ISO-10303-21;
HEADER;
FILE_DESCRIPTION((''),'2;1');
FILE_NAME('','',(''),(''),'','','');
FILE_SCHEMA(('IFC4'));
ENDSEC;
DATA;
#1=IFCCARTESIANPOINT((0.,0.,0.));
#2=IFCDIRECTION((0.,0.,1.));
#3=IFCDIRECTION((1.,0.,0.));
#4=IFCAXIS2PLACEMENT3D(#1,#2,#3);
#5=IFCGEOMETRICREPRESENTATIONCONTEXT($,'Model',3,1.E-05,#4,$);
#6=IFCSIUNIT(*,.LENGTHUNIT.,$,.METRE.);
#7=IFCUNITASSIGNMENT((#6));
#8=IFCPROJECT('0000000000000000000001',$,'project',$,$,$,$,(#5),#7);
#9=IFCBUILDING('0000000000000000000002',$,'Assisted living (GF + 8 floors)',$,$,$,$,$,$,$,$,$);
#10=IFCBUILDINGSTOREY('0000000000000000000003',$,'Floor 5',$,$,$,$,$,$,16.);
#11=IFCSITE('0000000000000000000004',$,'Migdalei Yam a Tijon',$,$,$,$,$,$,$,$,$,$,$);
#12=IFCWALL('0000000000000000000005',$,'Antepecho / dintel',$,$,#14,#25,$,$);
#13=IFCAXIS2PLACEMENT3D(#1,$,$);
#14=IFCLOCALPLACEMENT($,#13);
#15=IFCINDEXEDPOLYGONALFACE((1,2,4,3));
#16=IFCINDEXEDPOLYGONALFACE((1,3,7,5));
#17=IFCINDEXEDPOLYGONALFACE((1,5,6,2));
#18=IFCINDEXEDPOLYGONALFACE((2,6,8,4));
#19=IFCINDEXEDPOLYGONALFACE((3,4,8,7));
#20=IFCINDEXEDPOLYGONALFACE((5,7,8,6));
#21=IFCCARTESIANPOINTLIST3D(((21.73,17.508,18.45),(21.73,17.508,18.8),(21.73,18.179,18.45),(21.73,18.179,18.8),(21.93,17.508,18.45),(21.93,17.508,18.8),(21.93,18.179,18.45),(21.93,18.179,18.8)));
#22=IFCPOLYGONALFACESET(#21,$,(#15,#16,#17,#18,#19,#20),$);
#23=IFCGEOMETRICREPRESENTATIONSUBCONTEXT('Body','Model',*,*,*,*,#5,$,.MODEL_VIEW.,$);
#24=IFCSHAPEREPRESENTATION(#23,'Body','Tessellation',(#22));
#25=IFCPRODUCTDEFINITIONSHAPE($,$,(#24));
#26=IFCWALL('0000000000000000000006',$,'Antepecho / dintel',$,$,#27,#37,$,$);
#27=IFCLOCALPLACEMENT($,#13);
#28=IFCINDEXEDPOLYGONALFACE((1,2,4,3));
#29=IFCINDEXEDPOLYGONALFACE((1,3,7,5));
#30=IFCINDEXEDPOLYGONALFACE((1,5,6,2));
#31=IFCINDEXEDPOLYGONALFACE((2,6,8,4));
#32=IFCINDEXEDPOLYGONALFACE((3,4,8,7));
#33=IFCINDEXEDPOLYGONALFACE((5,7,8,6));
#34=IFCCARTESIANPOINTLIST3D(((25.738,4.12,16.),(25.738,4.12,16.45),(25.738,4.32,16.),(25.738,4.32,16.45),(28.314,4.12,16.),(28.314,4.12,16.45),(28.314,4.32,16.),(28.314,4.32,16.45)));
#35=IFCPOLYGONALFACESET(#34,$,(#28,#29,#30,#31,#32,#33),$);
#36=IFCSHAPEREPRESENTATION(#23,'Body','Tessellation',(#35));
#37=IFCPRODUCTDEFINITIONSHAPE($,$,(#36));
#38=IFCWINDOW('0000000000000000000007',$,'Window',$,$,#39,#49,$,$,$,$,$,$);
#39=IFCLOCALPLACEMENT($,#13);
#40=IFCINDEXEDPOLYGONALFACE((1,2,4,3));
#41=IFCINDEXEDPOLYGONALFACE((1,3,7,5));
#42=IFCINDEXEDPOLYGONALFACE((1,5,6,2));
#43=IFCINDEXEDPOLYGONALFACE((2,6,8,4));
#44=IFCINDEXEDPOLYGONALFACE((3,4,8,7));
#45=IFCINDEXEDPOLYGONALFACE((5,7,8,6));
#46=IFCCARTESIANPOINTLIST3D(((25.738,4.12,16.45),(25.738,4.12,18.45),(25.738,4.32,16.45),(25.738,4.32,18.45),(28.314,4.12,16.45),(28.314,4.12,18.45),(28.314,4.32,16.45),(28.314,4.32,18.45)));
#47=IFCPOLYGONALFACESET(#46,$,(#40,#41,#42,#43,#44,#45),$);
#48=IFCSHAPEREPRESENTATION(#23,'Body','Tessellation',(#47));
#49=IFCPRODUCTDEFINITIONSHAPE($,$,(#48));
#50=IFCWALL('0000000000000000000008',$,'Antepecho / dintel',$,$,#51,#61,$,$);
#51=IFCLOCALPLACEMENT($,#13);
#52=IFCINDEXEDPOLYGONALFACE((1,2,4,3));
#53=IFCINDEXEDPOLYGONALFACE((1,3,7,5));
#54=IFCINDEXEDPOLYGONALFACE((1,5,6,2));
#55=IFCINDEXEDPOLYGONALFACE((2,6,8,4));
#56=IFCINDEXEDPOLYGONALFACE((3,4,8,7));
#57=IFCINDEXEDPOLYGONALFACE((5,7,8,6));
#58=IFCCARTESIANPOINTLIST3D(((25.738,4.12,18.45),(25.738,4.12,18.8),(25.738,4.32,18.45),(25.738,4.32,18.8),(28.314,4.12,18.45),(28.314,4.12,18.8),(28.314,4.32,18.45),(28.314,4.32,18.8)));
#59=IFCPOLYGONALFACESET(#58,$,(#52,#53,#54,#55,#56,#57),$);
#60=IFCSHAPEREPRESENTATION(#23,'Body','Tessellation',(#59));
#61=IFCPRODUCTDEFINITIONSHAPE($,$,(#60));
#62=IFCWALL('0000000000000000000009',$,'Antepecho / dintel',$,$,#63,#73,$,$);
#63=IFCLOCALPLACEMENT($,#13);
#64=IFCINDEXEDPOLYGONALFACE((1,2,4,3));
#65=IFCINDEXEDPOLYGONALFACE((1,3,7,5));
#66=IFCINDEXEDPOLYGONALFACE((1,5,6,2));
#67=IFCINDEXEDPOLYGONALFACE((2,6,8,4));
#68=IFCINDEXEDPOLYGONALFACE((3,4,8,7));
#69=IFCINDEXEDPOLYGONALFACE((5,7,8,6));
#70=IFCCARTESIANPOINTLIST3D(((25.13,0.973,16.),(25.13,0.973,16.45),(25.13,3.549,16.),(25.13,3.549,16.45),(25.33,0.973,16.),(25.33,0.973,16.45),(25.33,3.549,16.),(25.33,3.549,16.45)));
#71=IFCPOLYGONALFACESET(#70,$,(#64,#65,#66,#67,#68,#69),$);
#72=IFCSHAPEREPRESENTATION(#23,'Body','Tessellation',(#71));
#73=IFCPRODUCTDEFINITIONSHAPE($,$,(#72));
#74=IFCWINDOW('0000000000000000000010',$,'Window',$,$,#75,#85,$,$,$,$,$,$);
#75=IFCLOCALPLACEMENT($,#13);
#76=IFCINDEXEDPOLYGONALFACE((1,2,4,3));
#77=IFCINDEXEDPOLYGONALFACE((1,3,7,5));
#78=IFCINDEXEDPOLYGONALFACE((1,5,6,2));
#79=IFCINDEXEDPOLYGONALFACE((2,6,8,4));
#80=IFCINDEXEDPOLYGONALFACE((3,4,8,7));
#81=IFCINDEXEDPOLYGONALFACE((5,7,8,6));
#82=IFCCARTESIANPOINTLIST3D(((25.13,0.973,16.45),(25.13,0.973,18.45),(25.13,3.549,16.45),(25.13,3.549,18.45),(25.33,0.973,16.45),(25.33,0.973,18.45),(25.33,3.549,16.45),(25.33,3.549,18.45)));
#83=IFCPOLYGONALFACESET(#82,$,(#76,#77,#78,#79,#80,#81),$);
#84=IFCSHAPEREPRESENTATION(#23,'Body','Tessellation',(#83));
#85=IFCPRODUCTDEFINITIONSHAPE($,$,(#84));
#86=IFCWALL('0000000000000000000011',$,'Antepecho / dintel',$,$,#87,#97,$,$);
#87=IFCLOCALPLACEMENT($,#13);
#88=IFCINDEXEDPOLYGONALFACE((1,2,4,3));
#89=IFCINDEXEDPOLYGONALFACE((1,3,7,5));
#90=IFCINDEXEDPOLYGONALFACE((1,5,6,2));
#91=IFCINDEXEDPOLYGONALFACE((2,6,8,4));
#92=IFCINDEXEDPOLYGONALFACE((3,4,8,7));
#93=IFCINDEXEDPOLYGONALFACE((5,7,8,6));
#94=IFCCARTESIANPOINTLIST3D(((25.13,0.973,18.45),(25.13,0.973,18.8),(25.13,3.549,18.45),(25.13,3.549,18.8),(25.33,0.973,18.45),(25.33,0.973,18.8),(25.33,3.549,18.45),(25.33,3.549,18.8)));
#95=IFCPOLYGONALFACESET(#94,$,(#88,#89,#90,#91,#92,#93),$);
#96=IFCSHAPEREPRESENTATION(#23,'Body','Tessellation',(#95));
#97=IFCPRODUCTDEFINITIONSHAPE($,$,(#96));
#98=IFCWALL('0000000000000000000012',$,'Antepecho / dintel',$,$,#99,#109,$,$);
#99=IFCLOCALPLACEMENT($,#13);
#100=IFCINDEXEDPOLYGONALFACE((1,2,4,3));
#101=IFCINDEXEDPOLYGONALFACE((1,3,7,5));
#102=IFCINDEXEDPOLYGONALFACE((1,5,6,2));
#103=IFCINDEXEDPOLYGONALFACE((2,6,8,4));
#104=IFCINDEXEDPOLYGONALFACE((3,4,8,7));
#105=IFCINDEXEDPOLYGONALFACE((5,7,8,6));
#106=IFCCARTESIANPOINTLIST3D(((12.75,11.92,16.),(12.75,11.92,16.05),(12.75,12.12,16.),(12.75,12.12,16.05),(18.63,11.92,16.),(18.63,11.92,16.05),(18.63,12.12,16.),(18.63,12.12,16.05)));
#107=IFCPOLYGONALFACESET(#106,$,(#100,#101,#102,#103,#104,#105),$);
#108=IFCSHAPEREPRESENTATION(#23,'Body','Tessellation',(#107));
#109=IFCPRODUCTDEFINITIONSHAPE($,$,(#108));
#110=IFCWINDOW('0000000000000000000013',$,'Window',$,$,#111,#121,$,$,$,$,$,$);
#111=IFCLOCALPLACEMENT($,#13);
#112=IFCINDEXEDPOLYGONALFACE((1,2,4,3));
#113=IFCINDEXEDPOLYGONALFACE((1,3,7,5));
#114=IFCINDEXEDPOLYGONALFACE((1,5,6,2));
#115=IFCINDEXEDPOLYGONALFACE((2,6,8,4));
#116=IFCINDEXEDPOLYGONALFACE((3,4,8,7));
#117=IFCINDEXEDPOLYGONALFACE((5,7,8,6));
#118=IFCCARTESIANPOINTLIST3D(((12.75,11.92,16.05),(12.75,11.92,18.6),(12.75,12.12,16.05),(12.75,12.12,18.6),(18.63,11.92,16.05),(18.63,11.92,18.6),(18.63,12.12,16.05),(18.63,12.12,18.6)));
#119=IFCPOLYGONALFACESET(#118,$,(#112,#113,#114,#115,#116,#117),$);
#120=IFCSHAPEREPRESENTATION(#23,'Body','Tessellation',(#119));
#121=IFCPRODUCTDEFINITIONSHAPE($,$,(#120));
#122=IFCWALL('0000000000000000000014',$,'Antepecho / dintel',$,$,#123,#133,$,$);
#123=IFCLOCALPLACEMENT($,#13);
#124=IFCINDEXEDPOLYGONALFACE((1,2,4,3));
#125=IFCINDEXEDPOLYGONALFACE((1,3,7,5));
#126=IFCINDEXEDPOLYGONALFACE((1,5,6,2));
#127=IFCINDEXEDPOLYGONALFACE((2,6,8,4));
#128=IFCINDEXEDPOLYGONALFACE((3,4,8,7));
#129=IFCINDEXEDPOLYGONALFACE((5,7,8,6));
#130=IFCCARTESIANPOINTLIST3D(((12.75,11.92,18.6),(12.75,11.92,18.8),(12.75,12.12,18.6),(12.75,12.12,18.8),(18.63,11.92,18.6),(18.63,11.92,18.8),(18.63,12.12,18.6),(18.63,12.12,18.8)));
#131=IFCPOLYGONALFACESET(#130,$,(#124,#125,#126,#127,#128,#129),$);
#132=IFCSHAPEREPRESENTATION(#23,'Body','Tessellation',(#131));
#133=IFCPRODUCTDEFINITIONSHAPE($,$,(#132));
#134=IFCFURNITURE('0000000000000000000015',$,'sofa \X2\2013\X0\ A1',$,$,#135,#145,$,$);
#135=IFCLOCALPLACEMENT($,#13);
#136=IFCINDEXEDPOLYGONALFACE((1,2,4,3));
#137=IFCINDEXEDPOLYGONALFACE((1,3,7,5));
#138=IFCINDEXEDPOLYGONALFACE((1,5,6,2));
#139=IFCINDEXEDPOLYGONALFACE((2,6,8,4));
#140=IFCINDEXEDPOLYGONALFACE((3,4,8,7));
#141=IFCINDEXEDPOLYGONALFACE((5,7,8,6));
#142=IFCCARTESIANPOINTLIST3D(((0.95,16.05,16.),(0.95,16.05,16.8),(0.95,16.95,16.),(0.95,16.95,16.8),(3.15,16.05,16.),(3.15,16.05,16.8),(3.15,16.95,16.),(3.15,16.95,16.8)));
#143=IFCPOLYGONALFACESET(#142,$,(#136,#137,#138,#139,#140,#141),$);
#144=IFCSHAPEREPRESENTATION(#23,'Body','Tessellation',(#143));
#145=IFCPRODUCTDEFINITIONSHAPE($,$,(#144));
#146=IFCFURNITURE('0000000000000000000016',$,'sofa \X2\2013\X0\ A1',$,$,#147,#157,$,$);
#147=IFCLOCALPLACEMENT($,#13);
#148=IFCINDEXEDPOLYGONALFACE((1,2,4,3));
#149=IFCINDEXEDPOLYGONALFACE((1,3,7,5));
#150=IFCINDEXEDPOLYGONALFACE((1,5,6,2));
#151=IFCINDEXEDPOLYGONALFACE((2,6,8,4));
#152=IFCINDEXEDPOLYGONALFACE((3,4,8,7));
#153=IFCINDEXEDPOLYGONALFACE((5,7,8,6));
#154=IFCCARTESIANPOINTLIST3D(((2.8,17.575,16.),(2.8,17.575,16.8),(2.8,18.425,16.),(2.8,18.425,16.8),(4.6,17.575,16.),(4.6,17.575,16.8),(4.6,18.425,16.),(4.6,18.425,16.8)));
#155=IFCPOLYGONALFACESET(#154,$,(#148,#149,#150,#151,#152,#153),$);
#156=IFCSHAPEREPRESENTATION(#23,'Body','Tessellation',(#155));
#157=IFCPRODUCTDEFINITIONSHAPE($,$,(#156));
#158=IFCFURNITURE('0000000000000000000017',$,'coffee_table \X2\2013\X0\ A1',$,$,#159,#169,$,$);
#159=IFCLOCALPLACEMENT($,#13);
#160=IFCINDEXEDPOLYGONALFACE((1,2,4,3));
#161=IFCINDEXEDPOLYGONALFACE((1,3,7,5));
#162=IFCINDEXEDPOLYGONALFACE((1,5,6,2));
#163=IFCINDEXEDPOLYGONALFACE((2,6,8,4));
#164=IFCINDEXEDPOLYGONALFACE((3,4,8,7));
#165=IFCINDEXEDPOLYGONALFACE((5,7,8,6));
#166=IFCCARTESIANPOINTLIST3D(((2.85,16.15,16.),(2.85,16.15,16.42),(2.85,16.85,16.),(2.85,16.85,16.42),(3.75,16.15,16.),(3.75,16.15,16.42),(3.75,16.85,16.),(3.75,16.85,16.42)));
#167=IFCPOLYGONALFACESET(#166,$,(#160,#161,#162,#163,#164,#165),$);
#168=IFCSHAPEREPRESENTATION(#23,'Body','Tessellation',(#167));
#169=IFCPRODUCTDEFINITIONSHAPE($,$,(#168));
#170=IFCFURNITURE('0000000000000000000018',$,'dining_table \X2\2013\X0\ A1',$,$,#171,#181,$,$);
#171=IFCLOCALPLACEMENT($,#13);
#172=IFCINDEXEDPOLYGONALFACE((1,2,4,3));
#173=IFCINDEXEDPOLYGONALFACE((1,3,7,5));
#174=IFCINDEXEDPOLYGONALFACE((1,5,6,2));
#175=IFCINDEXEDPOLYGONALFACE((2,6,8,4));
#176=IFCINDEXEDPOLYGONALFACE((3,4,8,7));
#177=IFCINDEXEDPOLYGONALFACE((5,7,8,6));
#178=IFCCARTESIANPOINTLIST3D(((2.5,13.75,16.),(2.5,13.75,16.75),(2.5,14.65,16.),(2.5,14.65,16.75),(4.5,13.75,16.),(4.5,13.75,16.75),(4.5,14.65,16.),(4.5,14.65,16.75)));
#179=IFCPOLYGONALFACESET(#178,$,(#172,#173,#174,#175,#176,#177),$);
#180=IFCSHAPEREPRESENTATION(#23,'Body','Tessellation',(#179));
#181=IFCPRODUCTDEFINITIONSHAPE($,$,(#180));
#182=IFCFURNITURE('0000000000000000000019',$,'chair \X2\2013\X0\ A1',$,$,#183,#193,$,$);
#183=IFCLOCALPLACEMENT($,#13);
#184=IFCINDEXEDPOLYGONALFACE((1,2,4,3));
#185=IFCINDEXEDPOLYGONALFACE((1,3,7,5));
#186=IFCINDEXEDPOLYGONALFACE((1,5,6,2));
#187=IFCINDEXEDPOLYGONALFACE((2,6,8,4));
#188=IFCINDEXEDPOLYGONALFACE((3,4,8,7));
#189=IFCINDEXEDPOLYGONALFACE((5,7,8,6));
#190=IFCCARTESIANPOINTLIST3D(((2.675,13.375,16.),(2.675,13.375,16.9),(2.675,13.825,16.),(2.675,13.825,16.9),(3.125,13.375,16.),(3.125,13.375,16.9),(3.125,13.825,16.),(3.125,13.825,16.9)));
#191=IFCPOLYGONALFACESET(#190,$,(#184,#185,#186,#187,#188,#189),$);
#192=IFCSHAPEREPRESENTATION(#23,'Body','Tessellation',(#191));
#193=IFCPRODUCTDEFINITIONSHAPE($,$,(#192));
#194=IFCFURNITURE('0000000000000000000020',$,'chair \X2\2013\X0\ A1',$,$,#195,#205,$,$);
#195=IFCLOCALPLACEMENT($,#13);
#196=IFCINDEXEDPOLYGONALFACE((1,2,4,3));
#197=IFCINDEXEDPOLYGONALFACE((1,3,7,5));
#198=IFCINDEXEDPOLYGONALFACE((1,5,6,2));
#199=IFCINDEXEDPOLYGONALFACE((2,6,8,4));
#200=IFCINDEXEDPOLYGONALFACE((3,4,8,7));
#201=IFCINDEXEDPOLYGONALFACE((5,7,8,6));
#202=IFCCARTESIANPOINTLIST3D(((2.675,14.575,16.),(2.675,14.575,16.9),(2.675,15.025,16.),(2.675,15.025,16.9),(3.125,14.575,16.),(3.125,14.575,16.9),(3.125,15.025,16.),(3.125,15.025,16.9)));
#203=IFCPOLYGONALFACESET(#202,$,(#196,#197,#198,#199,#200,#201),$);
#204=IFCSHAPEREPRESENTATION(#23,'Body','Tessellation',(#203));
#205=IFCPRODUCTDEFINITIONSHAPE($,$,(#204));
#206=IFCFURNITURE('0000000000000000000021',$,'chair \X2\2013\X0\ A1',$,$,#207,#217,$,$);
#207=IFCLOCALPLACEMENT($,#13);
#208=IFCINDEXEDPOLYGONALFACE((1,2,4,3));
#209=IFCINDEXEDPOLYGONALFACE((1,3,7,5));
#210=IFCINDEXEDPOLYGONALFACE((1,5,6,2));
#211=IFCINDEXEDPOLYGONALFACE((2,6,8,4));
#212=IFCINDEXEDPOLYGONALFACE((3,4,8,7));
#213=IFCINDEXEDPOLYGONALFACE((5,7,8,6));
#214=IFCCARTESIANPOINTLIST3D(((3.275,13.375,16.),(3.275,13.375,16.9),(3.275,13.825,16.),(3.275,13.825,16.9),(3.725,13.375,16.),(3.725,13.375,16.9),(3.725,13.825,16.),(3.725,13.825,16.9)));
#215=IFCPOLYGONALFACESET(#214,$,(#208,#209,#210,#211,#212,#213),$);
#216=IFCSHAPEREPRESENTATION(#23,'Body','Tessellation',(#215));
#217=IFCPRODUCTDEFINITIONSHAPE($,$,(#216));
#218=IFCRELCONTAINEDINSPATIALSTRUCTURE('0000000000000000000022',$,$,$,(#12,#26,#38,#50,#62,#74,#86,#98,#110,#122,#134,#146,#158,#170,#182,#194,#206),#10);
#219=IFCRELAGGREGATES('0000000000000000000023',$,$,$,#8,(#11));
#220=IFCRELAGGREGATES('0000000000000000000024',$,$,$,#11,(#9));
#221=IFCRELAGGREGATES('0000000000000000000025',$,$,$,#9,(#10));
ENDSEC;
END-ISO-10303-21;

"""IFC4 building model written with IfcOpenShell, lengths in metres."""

from ifc_helpers import new_model, si_unit, frame, origin_with_axes, context, subcontext, project, spatial, line, indexed_curve, outline, extrude, element, save


model = new_model("IFC4")

# Units and contexts
model_context = context("Model", 3, precision=1e-05, world=origin_with_axes())
body_context = subcontext(model_context, "Body", "Model", "MODEL_VIEW")
ifc_project = project(units=[si_unit("LENGTHUNIT", "METRE")], contexts=[model_context])

# Site, building, storey
site = spatial("IfcSite", under=ifc_project, Name="Migdalei Yam a Tijon")
building = spatial("IfcBuilding", under=site, Name="Assisted living (GF + 8 floors)")
storey = spatial("IfcBuildingStorey", under=building, Name="Floor 5", Elevation=16.0)

# Walls
element("IfcWall", 1, inside=storey, Name="Antepecho / dintel", context=body_context, shape_type="SweptSolid", body=[
    extrude(outline(indexed_curve([(0.0, 0.0), (0.2, 0.0), (0.2, 0.671), (0.0, 0.671)], segments=[line(1, 2, 3, 4, 1)])), frame((21.73, 17.508, 18.45), z_axis=(0.0, 0.0, 1.0), x_axis=(1.0, 0.0, 0.0)), (0.0, 0.0, 1.0), 0.35),
])
element("IfcWall", 2, inside=storey, Name="Antepecho / dintel", context=body_context, shape_type="SweptSolid", body=[
    extrude(outline(indexed_curve([(0.0, 0.0), (2.576, 0.0), (2.576, 0.2), (0.0, 0.2)], segments=[line(1, 2, 3, 4, 1)])), frame((25.738, 4.12, 16.0), z_axis=(0.0, 0.0, 1.0), x_axis=(1.0, 0.0, 0.0)), (0.0, 0.0, 1.0), 0.45),
])

# Window
element("IfcWindow", 3, inside=storey, Name="Window", context=body_context, shape_type="SweptSolid", body=[
    extrude(outline(indexed_curve([(0.0, 0.0), (2.576, 0.0), (2.576, 0.2), (0.0, 0.2)], segments=[line(1, 2, 3, 4, 1)])), frame((25.738, 4.12, 16.45), z_axis=(0.0, 0.0, 1.0), x_axis=(1.0, 0.0, 0.0)), (0.0, 0.0, 1.0), 2.0),
])

# Walls
element("IfcWall", 4, inside=storey, Name="Antepecho / dintel", context=body_context, shape_type="SweptSolid", body=[
    extrude(outline(indexed_curve([(0.0, 0.0), (2.576, 0.0), (2.576, 0.2), (0.0, 0.2)], segments=[line(1, 2, 3, 4, 1)])), frame((25.738, 4.12, 18.45), z_axis=(0.0, 0.0, 1.0), x_axis=(1.0, 0.0, 0.0)), (0.0, 0.0, 1.0), 0.35),
])
element("IfcWall", 5, inside=storey, Name="Antepecho / dintel", context=body_context, shape_type="SweptSolid", body=[
    extrude(outline(indexed_curve([(0.0, 0.0), (0.2, 0.0), (0.2, 2.576), (0.0, 2.576)], segments=[line(1, 2, 3, 4, 1)])), frame((25.13, 0.973, 16.0), z_axis=(0.0, 0.0, 1.0), x_axis=(1.0, 0.0, 0.0)), (0.0, 0.0, 1.0), 0.45),
])

# Window
element("IfcWindow", 6, inside=storey, Name="Window", context=body_context, shape_type="SweptSolid", body=[
    extrude(outline(indexed_curve([(0.0, 0.0), (0.2, 0.0), (0.2, 2.576), (0.0, 2.576)], segments=[line(1, 2, 3, 4, 1)])), frame((25.13, 0.973, 16.45), z_axis=(0.0, 0.0, 1.0), x_axis=(1.0, 0.0, 0.0)), (0.0, 0.0, 1.0), 2.0),
])

# Walls
element("IfcWall", 7, inside=storey, Name="Antepecho / dintel", context=body_context, shape_type="SweptSolid", body=[
    extrude(outline(indexed_curve([(0.0, 0.0), (0.2, 0.0), (0.2, 2.576), (0.0, 2.576)], segments=[line(1, 2, 3, 4, 1)])), frame((25.13, 0.973, 18.45), z_axis=(0.0, 0.0, 1.0), x_axis=(1.0, 0.0, 0.0)), (0.0, 0.0, 1.0), 0.35),
])
element("IfcWall", 8, inside=storey, Name="Antepecho / dintel", context=body_context, shape_type="SweptSolid", body=[
    extrude(outline(indexed_curve([(0.0, 0.0), (5.88, 0.0), (5.88, 0.2), (0.0, 0.2)], segments=[line(1, 2, 3, 4, 1)])), frame((12.75, 11.92, 16.0), z_axis=(0.0, 0.0, 1.0), x_axis=(1.0, 0.0, 0.0)), (0.0, 0.0, 1.0), 0.05),
])

# Window
element("IfcWindow", 9, inside=storey, Name="Window", context=body_context, shape_type="SweptSolid", body=[
    extrude(outline(indexed_curve([(0.0, 0.0), (5.88, 0.0), (5.88, 0.2), (0.0, 0.2)], segments=[line(1, 2, 3, 4, 1)])), frame((12.75, 11.92, 16.05), z_axis=(0.0, 0.0, 1.0), x_axis=(1.0, 0.0, 0.0)), (0.0, 0.0, 1.0), 2.55),
])

# Wall
element("IfcWall", 10, inside=storey, Name="Antepecho / dintel", context=body_context, shape_type="SweptSolid", body=[
    extrude(outline(indexed_curve([(0.0, 0.0), (5.88, 0.0), (5.88, 0.2), (0.0, 0.2)], segments=[line(1, 2, 3, 4, 1)])), frame((12.75, 11.92, 18.6), z_axis=(0.0, 0.0, 1.0), x_axis=(1.0, 0.0, 0.0)), (0.0, 0.0, 1.0), 0.2),
])

# Furniture
element("IfcFurniture", 11, inside=storey, Name="sofa – A1", context=body_context, shape_type="SweptSolid", body=[
    extrude(outline(indexed_curve([(0.0, 0.0), (2.2, 0.0), (2.2, 0.9), (0.0, 0.9)], segments=[line(1, 2, 3, 4, 1)])), frame((0.95, 16.05, 16.0), z_axis=(0.0, 0.0, 1.0), x_axis=(1.0, 0.0, 0.0)), (0.0, 0.0, 1.0), 0.8),
])
element("IfcFurniture", 12, inside=storey, Name="sofa – A1", context=body_context, shape_type="SweptSolid", body=[
    extrude(outline(indexed_curve([(0.0, 0.0), (1.8, 0.0), (1.8, 0.85), (0.0, 0.85)], segments=[line(1, 2, 3, 4, 1)])), frame((2.8, 17.575, 16.0), z_axis=(0.0, 0.0, 1.0), x_axis=(1.0, 0.0, 0.0)), (0.0, 0.0, 1.0), 0.8),
])
element("IfcFurniture", 13, inside=storey, Name="coffee_table – A1", context=body_context, shape_type="SweptSolid", body=[
    extrude(outline(indexed_curve([(0.0, 0.0), (0.9, 0.0), (0.9, 0.7), (0.0, 0.7)], segments=[line(1, 2, 3, 4, 1)])), frame((2.85, 16.15, 16.0), z_axis=(0.0, 0.0, 1.0), x_axis=(1.0, 0.0, 0.0)), (0.0, 0.0, 1.0), 0.42),
])
element("IfcFurniture", 14, inside=storey, Name="dining_table – A1", context=body_context, shape_type="SweptSolid", body=[
    extrude(outline(indexed_curve([(0.0, 0.0), (2.0, 0.0), (2.0, 0.9), (0.0, 0.9)], segments=[line(1, 2, 3, 4, 1)])), frame((2.5, 13.75, 16.0), z_axis=(0.0, 0.0, 1.0), x_axis=(1.0, 0.0, 0.0)), (0.0, 0.0, 1.0), 0.75),
])
element("IfcFurniture", 15, inside=storey, Name="chair – A1", context=body_context, shape_type="SweptSolid", body=[
    extrude(outline(indexed_curve([(0.0, 0.0), (0.45, 0.0), (0.45, 0.45), (0.0, 0.45)], segments=[line(1, 2, 3, 4, 1)])), frame((2.675, 13.375, 16.0), z_axis=(0.0, 0.0, 1.0), x_axis=(1.0, 0.0, 0.0)), (0.0, 0.0, 1.0), 0.9),
])
element("IfcFurniture", 16, inside=storey, Name="chair – A1", context=body_context, shape_type="SweptSolid", body=[
    extrude(outline(indexed_curve([(0.0, 0.0), (0.45, 0.0), (0.45, 0.45), (0.0, 0.45)], segments=[line(1, 2, 3, 4, 1)])), frame((2.675, 14.575, 16.0), z_axis=(0.0, 0.0, 1.0), x_axis=(1.0, 0.0, 0.0)), (0.0, 0.0, 1.0), 0.9),
])
element("IfcFurniture", 17, inside=storey, Name="chair – A1", context=body_context, shape_type="SweptSolid", body=[
    extrude(outline(indexed_curve([(0.0, 0.0), (0.45, 0.0), (0.45, 0.45), (0.0, 0.45)], segments=[line(1, 2, 3, 4, 1)])), frame((3.275, 13.375, 16.0), z_axis=(0.0, 0.0, 1.0), x_axis=(1.0, 0.0, 0.0)), (0.0, 0.0, 1.0), 0.9),
])

save(model, "model.ifc")
